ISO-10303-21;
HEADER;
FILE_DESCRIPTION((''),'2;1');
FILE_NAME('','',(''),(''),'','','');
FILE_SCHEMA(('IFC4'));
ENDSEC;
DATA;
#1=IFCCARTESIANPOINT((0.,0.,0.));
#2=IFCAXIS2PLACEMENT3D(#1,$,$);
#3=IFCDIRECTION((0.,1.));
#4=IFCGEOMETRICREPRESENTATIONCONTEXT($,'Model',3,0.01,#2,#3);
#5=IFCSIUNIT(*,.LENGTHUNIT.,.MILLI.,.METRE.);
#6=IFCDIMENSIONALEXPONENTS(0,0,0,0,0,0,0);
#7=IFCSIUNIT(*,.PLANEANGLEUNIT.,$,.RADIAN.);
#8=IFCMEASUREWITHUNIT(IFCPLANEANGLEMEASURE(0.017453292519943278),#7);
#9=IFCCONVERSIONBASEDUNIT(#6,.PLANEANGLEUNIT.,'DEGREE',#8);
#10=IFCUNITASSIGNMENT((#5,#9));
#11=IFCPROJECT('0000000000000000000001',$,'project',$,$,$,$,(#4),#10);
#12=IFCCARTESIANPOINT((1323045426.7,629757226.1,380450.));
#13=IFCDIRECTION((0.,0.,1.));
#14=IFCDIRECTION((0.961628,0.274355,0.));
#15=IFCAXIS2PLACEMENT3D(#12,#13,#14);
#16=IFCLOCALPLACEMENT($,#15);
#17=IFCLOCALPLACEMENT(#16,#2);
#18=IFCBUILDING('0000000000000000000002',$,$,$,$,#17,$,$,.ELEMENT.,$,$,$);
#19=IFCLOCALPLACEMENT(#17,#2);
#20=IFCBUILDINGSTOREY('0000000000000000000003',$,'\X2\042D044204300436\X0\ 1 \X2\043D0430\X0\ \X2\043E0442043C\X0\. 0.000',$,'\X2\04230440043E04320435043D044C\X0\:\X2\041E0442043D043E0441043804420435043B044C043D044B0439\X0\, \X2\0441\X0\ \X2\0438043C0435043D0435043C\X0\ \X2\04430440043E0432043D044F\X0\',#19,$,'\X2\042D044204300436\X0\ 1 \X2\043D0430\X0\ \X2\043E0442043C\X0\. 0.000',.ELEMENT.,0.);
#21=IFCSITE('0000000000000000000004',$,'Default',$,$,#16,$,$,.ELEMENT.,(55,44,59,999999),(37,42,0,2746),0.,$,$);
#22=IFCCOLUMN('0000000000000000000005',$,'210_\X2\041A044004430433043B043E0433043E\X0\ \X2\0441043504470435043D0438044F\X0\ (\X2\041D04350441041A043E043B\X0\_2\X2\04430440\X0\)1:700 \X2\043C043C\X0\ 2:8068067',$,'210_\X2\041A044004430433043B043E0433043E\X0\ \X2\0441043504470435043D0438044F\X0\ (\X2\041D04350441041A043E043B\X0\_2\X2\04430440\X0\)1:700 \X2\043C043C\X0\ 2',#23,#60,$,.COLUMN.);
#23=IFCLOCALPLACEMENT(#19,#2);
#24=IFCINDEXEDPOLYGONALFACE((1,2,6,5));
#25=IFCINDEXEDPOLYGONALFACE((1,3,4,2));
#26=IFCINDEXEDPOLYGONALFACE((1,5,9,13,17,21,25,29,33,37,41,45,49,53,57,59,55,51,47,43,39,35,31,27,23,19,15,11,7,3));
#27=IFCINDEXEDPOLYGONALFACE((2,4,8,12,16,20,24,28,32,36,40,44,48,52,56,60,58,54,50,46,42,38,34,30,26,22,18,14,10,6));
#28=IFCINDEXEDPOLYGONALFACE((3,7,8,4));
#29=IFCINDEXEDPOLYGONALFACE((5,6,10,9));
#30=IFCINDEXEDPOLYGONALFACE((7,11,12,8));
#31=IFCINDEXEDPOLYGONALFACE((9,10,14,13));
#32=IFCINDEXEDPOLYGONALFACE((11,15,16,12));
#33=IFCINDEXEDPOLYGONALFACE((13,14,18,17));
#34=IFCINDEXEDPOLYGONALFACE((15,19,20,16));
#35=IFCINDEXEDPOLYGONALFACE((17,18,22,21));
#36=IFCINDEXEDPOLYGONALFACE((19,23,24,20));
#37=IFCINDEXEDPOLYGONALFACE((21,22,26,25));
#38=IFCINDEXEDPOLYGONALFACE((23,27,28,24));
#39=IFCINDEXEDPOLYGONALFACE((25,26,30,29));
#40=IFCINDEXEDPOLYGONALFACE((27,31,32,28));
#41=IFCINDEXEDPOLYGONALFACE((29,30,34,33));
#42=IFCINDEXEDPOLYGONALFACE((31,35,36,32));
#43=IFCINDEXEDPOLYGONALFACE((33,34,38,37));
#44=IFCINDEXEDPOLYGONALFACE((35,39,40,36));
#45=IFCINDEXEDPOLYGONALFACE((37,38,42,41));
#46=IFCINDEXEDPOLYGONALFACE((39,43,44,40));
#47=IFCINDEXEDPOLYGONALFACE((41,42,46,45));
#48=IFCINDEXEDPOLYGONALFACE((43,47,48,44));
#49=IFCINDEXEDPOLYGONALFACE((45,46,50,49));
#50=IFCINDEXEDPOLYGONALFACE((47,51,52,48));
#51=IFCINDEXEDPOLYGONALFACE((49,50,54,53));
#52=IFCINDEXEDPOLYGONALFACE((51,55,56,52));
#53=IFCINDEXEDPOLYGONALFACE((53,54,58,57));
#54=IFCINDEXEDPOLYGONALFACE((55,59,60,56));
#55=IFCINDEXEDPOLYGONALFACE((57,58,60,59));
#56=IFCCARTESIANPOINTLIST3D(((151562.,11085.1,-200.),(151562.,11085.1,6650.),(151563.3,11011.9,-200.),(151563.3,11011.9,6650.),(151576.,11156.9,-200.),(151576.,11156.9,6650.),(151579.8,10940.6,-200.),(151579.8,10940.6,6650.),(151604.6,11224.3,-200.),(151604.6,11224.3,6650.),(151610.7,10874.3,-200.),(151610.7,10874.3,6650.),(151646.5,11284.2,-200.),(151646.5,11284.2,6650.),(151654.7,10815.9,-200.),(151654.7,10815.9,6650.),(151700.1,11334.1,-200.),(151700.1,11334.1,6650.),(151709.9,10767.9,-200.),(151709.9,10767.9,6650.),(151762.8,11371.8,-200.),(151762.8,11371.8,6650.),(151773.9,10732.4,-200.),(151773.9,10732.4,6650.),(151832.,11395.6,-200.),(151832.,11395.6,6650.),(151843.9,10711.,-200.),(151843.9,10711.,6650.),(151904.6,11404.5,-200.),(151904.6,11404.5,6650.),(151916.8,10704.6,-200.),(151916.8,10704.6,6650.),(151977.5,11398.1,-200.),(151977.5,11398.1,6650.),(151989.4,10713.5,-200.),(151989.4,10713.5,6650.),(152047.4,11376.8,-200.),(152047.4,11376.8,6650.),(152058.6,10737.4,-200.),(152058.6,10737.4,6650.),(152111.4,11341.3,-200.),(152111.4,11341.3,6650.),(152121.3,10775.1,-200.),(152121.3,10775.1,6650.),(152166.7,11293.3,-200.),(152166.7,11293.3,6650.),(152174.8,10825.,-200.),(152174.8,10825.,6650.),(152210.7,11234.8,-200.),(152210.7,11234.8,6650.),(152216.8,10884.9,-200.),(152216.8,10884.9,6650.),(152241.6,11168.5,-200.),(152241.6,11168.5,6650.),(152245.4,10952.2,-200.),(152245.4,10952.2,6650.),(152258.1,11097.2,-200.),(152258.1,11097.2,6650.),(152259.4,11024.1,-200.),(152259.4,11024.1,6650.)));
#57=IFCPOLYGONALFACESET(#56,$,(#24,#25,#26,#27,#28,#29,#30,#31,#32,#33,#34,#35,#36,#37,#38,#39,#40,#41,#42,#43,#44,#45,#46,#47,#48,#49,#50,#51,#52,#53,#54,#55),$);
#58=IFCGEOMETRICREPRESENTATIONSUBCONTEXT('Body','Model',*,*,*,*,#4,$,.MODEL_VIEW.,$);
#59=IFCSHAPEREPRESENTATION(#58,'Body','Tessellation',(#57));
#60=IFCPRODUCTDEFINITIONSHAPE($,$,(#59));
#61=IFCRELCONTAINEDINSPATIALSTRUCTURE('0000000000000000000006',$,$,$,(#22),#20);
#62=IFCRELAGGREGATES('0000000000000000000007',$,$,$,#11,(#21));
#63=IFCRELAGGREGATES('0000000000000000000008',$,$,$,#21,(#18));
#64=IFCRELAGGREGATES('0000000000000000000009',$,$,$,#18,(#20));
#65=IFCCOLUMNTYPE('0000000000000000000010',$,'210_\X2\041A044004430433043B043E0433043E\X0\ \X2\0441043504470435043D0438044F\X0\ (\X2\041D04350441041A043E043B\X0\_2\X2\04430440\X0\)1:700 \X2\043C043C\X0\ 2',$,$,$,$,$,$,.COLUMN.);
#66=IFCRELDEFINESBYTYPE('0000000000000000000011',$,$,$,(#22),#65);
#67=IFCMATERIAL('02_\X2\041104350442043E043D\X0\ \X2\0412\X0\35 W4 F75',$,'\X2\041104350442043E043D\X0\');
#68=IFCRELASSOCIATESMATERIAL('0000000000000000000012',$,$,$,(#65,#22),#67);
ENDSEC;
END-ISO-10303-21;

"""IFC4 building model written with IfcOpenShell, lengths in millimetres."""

from ifc_helpers import new_model, entity, si_unit, converted_unit, direction, frame, origin, place, context, subcontext, project, spatial, arc, indexed_curve, outline, extrude, source, transform, mapped, material, type_object, type_shapes, element, save


model = new_model("IFC4")

# Units and contexts
model_context = context("Model", 3, precision=0.01, world=origin(), true_north=direction((0.0, 1.0)))
body_context = subcontext(model_context, "Body", "Model", "MODEL_VIEW")
ifc_project = project(units=[si_unit("LENGTHUNIT", "METRE", prefix="MILLI"), converted_unit("PLANEANGLEUNIT", "DEGREE", entity("IfcPlaneAngleMeasure", 0.017453292519943278), si_unit("PLANEANGLEUNIT", "RADIAN"), dimensions=[0, 0, 0, 0, 0, 0, 0])], contexts=[model_context])

# Site, building, storey
site_placement = place(None, frame((1323045426.7, 629757226.1, 380450.0), z_axis=(0.0, 0.0, 1.0), x_axis=(0.961628, 0.274355, 0.0)))
site = spatial("IfcSite", under=ifc_project, at=site_placement, Name="Default", CompositionType="ELEMENT", RefLatitude=(55, 44, 59, 999999), RefLongitude=(37, 42, 0, 2746), RefElevation=0.0)
building_placement = place(site_placement, origin())
building = spatial("IfcBuilding", under=site, at=building_placement, CompositionType="ELEMENT")
storey_placement = place(building_placement, origin())
storey = spatial("IfcBuildingStorey", under=building, at=storey_placement, Name="Этаж 1 на отм. 0.000", ObjectType="Уровень:Относительный, с именем уровня", LongName="Этаж 1 на отм. 0.000", CompositionType="ELEMENT", Elevation=0.0)

# Column
ifc_material = material(Name="02_Бетон В35 W4 F75", Category="Бетон")
column_type_1 = type_object("IfcColumnType", Name="210_Круглого сечения (НесКол_2ур)1:700 мм 2", PredefinedType="COLUMN", material=ifc_material)
shared_shape_1 = source(origin(), body_context, "Body", "SweptSolid", [
    extrude(outline(indexed_curve([(-350.0, 0.0), (0.0, -350.0), (350.0, 0.0), (0.0, 350.0)], segments=[arc(1, 2, 3), arc(3, 4, 1)], self_intersect=False)), frame((151910.7, 11054.6, -200.0), z_axis=(0.0, 0.0, 1.0), x_axis=(0.87462, -0.48481, 0.0)), (0.0, 0.0, 1.0), 6850.0),
])
type_shapes(column_type_1, [shared_shape_1])
column_1_placement = place(storey_placement, origin())
element("IfcColumn", 1, at=column_1_placement, inside=storey, type_object=column_type_1, material=ifc_material, Name="210_Круглого сечения (НесКол_2ур)1:700 мм 2:8068067", ObjectType="210_Круглого сечения (НесКол_2ур)1:700 мм 2", PredefinedType="COLUMN", context=body_context, shape_type="MappedRepresentation", body=[
    mapped(shared_shape_1, transform((0.0, 0.0, 0.0), scale=1.0)),
])

save(model, "model.ifc")
